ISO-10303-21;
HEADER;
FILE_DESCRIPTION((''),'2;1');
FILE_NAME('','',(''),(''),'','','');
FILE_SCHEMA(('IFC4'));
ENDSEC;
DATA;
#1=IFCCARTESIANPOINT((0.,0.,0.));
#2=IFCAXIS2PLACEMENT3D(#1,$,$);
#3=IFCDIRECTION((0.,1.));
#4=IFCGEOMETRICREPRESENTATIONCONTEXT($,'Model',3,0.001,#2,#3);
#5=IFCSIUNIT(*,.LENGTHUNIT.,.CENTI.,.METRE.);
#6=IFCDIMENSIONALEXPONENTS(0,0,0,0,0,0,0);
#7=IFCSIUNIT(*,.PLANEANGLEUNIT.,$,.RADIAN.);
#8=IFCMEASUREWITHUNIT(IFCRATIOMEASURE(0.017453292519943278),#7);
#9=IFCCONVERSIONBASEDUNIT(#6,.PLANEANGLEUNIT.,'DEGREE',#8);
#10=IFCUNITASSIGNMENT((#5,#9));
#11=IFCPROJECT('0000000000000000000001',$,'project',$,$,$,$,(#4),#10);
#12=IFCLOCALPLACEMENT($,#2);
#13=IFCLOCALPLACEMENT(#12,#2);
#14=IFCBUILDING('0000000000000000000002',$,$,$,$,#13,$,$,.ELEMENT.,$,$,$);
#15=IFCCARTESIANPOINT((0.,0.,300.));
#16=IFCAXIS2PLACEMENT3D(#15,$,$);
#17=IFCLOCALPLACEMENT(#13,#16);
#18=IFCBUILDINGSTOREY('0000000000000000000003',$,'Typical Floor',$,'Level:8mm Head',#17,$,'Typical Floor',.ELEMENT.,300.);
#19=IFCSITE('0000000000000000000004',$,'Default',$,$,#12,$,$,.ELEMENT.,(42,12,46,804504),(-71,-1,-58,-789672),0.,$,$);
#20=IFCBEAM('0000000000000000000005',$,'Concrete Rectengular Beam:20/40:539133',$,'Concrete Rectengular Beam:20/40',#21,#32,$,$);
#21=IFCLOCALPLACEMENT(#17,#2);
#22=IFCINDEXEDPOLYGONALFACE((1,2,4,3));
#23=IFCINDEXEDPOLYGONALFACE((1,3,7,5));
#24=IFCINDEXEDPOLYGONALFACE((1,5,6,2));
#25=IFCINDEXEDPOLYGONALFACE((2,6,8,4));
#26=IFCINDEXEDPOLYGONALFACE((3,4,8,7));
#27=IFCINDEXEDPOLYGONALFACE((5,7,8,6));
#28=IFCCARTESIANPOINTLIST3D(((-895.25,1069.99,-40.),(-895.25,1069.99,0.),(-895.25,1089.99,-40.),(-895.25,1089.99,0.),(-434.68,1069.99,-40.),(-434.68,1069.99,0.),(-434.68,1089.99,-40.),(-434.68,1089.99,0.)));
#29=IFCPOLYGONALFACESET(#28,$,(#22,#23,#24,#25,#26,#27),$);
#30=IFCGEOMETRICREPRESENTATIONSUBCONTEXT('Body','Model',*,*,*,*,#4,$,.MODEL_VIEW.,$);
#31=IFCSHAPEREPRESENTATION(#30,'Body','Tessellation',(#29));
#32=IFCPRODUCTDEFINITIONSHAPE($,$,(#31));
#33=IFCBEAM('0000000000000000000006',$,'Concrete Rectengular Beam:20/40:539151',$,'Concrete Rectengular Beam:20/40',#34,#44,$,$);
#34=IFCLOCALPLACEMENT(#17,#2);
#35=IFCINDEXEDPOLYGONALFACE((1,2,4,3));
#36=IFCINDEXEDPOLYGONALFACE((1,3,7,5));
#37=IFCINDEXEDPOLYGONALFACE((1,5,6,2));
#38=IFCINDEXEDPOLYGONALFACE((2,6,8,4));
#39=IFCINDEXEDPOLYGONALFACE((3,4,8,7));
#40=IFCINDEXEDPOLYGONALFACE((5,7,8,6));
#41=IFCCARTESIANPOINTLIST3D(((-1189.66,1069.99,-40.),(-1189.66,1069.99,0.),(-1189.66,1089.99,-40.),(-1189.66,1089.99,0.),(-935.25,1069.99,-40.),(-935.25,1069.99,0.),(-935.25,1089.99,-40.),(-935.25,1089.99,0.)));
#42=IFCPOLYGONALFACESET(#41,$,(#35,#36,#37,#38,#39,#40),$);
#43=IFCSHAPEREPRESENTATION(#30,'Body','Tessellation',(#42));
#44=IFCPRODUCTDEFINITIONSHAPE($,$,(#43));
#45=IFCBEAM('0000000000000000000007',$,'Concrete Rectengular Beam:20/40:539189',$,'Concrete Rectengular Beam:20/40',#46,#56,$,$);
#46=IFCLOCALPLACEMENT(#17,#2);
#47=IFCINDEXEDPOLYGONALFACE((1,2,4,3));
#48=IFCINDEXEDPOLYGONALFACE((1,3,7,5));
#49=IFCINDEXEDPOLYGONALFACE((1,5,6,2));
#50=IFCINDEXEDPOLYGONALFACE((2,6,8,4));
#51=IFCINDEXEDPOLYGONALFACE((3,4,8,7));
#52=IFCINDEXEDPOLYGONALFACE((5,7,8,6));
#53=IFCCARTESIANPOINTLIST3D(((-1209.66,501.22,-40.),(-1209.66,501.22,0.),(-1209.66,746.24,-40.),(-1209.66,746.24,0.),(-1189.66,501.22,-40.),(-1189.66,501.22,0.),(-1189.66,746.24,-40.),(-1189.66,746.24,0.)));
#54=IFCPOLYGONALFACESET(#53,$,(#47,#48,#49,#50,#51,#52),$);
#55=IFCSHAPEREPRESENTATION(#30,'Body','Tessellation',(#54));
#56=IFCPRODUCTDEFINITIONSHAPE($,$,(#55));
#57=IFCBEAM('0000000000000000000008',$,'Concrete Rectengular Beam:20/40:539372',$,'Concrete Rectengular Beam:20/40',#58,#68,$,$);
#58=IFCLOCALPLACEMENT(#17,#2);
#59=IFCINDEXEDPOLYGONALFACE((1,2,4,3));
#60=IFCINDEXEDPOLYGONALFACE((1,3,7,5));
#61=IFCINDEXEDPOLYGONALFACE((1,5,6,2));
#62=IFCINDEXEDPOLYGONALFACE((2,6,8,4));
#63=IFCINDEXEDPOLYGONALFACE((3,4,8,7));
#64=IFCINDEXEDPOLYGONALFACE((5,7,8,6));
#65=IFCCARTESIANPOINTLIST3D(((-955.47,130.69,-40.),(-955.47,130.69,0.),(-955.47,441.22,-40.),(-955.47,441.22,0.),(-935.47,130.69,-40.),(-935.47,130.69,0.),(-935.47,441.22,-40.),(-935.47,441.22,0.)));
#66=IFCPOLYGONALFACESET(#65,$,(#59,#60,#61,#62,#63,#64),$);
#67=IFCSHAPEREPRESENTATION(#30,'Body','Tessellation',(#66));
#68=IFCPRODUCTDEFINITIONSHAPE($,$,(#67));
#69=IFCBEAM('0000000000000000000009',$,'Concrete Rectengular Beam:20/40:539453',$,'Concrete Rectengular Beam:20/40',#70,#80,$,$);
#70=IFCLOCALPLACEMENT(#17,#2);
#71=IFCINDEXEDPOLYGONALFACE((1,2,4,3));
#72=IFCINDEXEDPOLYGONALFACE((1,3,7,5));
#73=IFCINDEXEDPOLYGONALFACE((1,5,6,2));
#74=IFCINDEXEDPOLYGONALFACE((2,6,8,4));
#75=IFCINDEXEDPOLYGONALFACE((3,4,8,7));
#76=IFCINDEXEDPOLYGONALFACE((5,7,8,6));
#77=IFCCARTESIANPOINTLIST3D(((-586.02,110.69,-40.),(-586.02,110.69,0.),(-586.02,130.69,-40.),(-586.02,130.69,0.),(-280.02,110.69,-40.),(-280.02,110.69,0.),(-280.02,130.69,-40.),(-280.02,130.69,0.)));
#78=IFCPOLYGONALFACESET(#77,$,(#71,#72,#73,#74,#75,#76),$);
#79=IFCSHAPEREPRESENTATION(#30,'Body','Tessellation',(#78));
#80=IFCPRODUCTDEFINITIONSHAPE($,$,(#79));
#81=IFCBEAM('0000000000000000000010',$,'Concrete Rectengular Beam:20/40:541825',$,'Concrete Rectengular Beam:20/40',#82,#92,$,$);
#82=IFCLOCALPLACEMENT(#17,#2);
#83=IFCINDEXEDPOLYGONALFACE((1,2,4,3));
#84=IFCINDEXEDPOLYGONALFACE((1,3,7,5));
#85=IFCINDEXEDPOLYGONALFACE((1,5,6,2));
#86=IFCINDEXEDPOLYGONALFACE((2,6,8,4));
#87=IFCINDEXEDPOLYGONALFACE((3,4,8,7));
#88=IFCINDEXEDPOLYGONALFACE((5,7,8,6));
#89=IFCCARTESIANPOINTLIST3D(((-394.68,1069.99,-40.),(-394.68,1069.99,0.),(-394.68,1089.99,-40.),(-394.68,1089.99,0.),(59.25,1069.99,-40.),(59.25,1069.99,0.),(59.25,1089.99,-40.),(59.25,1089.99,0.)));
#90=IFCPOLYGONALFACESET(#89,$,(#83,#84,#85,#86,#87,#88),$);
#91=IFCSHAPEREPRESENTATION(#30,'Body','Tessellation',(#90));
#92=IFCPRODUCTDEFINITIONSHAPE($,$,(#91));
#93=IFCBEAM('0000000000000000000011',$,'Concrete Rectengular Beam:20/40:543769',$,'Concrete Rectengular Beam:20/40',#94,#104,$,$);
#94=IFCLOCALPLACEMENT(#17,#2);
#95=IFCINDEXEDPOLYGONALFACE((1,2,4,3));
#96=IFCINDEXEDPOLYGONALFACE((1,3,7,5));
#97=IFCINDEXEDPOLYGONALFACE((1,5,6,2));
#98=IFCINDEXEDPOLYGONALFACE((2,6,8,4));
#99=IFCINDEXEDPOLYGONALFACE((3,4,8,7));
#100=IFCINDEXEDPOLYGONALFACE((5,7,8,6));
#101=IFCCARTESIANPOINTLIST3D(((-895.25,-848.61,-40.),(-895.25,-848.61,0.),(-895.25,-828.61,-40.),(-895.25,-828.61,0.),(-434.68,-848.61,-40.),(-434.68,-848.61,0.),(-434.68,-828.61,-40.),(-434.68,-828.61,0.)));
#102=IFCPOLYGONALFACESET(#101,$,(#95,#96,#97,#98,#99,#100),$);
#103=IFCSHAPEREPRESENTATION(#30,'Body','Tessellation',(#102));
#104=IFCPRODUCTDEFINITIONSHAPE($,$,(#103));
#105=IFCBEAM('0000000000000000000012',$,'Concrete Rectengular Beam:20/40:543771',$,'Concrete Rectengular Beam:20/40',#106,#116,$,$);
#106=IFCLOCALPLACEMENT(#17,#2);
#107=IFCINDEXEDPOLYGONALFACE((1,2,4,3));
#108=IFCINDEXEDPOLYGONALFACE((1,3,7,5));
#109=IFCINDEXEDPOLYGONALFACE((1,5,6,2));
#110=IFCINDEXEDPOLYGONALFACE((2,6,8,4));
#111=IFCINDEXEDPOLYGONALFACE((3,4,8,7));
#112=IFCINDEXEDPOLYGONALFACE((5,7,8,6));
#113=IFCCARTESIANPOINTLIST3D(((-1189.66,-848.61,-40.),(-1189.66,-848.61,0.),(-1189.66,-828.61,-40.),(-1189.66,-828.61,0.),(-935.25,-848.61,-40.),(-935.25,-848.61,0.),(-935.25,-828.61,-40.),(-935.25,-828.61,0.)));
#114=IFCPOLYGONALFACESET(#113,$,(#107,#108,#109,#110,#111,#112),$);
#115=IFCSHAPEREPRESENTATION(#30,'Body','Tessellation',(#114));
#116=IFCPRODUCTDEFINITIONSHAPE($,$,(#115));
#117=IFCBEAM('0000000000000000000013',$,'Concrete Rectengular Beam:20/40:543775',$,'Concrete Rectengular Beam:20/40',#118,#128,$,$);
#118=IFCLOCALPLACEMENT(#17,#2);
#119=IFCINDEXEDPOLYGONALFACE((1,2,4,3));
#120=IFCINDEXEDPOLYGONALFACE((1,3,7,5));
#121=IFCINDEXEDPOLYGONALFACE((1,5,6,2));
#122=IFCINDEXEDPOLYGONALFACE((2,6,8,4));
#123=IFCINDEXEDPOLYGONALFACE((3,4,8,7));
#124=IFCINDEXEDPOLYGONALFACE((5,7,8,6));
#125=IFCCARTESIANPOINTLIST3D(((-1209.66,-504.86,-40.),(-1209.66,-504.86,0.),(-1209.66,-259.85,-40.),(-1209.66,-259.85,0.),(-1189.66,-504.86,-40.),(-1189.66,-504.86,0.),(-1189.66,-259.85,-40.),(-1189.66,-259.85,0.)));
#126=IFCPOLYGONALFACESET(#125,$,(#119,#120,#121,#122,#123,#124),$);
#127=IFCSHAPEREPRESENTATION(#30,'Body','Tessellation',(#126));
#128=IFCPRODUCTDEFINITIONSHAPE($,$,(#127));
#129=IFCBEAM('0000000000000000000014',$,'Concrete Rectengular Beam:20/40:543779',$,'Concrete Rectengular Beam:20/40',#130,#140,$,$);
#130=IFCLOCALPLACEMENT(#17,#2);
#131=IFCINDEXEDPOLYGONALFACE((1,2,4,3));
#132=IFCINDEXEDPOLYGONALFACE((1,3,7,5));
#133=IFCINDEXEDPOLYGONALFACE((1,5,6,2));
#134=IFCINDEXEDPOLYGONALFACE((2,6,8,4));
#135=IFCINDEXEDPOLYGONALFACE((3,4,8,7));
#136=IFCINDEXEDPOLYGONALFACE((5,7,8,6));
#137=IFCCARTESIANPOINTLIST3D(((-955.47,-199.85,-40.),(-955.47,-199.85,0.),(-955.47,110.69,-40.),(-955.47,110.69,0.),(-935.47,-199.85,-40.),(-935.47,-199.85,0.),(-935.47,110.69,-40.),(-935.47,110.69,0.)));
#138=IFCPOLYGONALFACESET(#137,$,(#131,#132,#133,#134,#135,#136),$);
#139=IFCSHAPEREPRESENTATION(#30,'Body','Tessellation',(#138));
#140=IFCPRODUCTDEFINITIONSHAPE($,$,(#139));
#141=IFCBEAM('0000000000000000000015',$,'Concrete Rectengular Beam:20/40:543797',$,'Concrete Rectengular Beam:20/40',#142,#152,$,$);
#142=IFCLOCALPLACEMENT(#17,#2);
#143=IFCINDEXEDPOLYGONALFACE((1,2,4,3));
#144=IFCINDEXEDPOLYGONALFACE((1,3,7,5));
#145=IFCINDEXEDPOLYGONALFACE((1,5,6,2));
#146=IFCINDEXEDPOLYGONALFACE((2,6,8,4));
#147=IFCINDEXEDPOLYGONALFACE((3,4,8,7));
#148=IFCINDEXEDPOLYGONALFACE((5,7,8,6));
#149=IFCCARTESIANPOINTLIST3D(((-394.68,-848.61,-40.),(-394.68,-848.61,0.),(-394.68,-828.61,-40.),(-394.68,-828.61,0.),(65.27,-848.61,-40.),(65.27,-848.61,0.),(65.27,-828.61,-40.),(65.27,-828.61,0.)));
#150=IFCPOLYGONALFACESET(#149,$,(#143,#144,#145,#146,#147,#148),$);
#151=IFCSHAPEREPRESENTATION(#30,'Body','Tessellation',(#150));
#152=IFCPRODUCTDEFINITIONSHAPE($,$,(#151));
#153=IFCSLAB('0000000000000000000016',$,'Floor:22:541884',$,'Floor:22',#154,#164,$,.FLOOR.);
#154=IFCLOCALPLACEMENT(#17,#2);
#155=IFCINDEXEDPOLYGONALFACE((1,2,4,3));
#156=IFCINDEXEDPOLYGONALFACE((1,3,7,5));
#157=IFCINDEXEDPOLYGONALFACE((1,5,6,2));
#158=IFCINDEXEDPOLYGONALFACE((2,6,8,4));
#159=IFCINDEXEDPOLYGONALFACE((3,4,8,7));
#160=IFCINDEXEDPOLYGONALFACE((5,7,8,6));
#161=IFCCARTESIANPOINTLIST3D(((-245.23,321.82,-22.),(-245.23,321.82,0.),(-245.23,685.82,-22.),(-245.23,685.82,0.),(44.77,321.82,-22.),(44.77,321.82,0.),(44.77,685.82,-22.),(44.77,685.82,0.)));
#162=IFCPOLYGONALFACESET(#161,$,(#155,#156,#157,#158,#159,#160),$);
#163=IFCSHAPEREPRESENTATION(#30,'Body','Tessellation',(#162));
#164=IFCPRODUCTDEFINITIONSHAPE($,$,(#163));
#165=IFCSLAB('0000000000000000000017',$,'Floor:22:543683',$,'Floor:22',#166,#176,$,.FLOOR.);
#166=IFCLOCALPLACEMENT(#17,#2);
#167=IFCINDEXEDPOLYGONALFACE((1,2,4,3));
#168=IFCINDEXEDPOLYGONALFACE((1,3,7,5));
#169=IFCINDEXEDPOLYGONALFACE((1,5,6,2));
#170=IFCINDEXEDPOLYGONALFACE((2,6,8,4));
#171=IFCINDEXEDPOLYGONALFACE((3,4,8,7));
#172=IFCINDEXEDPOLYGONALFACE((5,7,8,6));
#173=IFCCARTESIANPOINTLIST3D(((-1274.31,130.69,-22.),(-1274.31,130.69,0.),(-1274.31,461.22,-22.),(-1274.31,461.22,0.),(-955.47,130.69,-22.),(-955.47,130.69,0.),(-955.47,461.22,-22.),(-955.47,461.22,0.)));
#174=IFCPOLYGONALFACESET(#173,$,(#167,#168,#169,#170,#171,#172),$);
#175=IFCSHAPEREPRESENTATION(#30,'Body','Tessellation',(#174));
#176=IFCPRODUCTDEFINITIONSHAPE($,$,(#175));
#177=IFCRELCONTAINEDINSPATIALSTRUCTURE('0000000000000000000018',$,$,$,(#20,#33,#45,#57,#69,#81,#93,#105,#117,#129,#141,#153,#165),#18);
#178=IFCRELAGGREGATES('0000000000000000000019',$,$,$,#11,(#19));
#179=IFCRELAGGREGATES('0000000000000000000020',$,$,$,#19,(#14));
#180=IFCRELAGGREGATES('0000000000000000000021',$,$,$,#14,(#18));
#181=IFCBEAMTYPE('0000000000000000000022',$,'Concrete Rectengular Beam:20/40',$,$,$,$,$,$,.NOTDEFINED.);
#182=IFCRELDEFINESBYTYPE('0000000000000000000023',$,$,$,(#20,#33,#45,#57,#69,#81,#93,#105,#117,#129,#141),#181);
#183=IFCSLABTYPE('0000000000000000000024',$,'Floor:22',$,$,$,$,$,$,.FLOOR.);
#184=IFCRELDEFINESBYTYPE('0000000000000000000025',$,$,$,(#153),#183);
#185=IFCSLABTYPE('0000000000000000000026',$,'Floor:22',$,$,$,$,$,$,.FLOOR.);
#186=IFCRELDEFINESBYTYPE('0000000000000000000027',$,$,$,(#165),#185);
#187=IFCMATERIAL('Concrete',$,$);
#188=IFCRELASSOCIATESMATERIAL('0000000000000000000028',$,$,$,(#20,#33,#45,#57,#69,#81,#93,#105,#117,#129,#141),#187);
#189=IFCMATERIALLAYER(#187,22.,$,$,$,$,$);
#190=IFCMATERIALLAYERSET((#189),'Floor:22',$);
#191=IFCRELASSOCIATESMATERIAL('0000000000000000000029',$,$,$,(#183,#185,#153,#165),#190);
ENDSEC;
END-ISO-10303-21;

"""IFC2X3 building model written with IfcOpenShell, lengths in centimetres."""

from ifc_helpers import new_model, entity, si_unit, converted_unit, direction, frame, frame_2d, origin, place, context, subcontext, project, spatial, rectangle, extrude, material, layer, layer_set, layer_usage, type_object, element, save


model = new_model("IFC2X3")

# Units and contexts
model_context = context("Model", 3, precision=0.001, world=origin(), true_north=direction((0.0, 1.0)))
body_context = subcontext(model_context, "Body", "Model", "MODEL_VIEW")
ifc_project = project(units=[si_unit("LENGTHUNIT", "METRE", prefix="CENTI"), converted_unit("PLANEANGLEUNIT", "DEGREE", entity("IfcRatioMeasure", 0.017453292519943278), si_unit("PLANEANGLEUNIT", "RADIAN"), dimensions=[0, 0, 0, 0, 0, 0, 0])], contexts=[model_context])

# Site, building, storey
site_placement = place(None, origin())
site = spatial("IfcSite", under=ifc_project, at=site_placement, Name="Default", CompositionType="ELEMENT", RefLatitude=(42, 12, 46, 804504), RefLongitude=(-71, -1, -58, -789672), RefElevation=0.0)
building_placement = place(site_placement, origin())
building = spatial("IfcBuilding", under=site, at=building_placement, CompositionType="ELEMENT")
storey_placement = place(building_placement, frame((0.0, 0.0, 300.0)))
storey = spatial("IfcBuildingStorey", under=building, at=storey_placement, Name="Typical Floor", ObjectType="Level:8mm Head", LongName="Typical Floor", CompositionType="ELEMENT", Elevation=300.0)

# Beams
ifc_material = material(Name="Concrete")
beam_type = type_object("IfcBeamType", Name="Concrete Rectengular Beam:20/40", PredefinedType="NOTDEFINED")
beam_1_placement = place(storey_placement, frame((-414.68, 1079.99, 0.0), z_axis=(0.0, 0.0, 1.0), x_axis=(-1.0, 0.0, 0.0)))
element("IfcBeam", 1, at=beam_1_placement, inside=storey, type_object=beam_type, material=ifc_material, Name="Concrete Rectengular Beam:20/40:539133", ObjectType="Concrete Rectengular Beam:20/40", context=body_context, shape_type="SweptSolid", body=[
    extrude(rectangle(XDim=40.0, YDim=20.0, at=frame_2d((0.0, 0.0), x_axis=(1.0, 0.0))), frame((20.0, 0.0, -20.0), z_axis=(1.0, 0.0, 0.0), x_axis=(0.0, 0.0, -1.0)), (0.0, 0.0, 1.0), 460.57),
])
beam_2_placement = place(storey_placement, frame((-915.25, 1079.99, 0.0), z_axis=(0.0, 0.0, 1.0), x_axis=(-1.0, 0.0, 0.0)))
element("IfcBeam", 2, at=beam_2_placement, inside=storey, type_object=beam_type, material=ifc_material, Name="Concrete Rectengular Beam:20/40:539151", ObjectType="Concrete Rectengular Beam:20/40", context=body_context, shape_type="SweptSolid", body=[
    extrude(rectangle(XDim=40.0, YDim=20.0, at=frame_2d((0.0, 0.0), x_axis=(1.0, 0.0))), frame((20.0, 0.0, -20.0), z_axis=(1.0, 0.0, 0.0), x_axis=(0.0, 0.0, -1.0)), (0.0, 0.0, 1.0), 254.41),
])
beam_3_placement = place(storey_placement, frame((-1199.66, 766.24, 0.0), z_axis=(0.0, 0.0, 1.0), x_axis=(0.0, -1.0, 0.0)))
element("IfcBeam", 3, at=beam_3_placement, inside=storey, type_object=beam_type, material=ifc_material, Name="Concrete Rectengular Beam:20/40:539189", ObjectType="Concrete Rectengular Beam:20/40", context=body_context, shape_type="SweptSolid", body=[
    extrude(rectangle(XDim=40.0, YDim=20.0, at=frame_2d((0.0, 0.0), x_axis=(1.0, 0.0))), frame((20.0, 0.0, -20.0), z_axis=(1.0, 0.0, 0.0), x_axis=(0.0, 0.0, -1.0)), (0.0, 0.0, 1.0), 245.01),
])
beam_4_placement = place(storey_placement, frame((-945.47, 461.22, 0.0), z_axis=(0.0, 0.0, 1.0), x_axis=(0.0, -1.0, 0.0)))
element("IfcBeam", 4, at=beam_4_placement, inside=storey, type_object=beam_type, material=ifc_material, Name="Concrete Rectengular Beam:20/40:539372", ObjectType="Concrete Rectengular Beam:20/40", context=body_context, shape_type="SweptSolid", body=[
    extrude(rectangle(XDim=40.0, YDim=20.0, at=frame_2d((0.0, 0.0), x_axis=(1.0, 0.0))), frame((20.0, 0.0, -20.0), z_axis=(1.0, 0.0, 0.0), x_axis=(0.0, 0.0, -1.0)), (0.0, 0.0, 1.0), 310.54),
])
beam_5_placement = place(storey_placement, frame((-606.02, 120.69, 0.0)))
element("IfcBeam", 5, at=beam_5_placement, inside=storey, type_object=beam_type, material=ifc_material, Name="Concrete Rectengular Beam:20/40:539453", ObjectType="Concrete Rectengular Beam:20/40", context=body_context, shape_type="SweptSolid", body=[
    extrude(rectangle(XDim=40.0, YDim=20.0, at=frame_2d((0.0, 0.0), x_axis=(1.0, 0.0))), frame((20.0, 0.0, -20.0), z_axis=(1.0, 0.0, 0.0), x_axis=(0.0, 0.0, -1.0)), (0.0, 0.0, 1.0), 306.0),
])
beam_6_placement = place(storey_placement, frame((-414.68, 1079.99, 0.0)))
element("IfcBeam", 6, at=beam_6_placement, inside=storey, type_object=beam_type, material=ifc_material, Name="Concrete Rectengular Beam:20/40:541825", ObjectType="Concrete Rectengular Beam:20/40", context=body_context, shape_type="SweptSolid", body=[
    extrude(rectangle(XDim=40.0, YDim=20.0, at=frame_2d((0.0, 0.0), x_axis=(1.0, 0.0))), frame((20.0, 0.0, -20.0), z_axis=(1.0, 0.0, 0.0), x_axis=(0.0, 0.0, -1.0)), (0.0, 0.0, 1.0), 453.93),
])
beam_7_placement = place(storey_placement, frame((-414.68, -838.61, 0.0), z_axis=(0.0, 0.0, 1.0), x_axis=(-1.0, 0.0, 0.0)))
element("IfcBeam", 7, at=beam_7_placement, inside=storey, type_object=beam_type, material=ifc_material, Name="Concrete Rectengular Beam:20/40:543769", ObjectType="Concrete Rectengular Beam:20/40", context=body_context, shape_type="SweptSolid", body=[
    extrude(rectangle(XDim=40.0, YDim=20.0, at=frame_2d((0.0, 0.0), x_axis=(1.0, 0.0))), frame((20.0, 0.0, -20.0), z_axis=(1.0, 0.0, 0.0), x_axis=(0.0, 0.0, -1.0)), (0.0, 0.0, 1.0), 460.57),
])
beam_8_placement = place(storey_placement, frame((-915.25, -838.61, 0.0), z_axis=(0.0, 0.0, 1.0), x_axis=(-1.0, 0.0, 0.0)))
element("IfcBeam", 8, at=beam_8_placement, inside=storey, type_object=beam_type, material=ifc_material, Name="Concrete Rectengular Beam:20/40:543771", ObjectType="Concrete Rectengular Beam:20/40", context=body_context, shape_type="SweptSolid", body=[
    extrude(rectangle(XDim=40.0, YDim=20.0, at=frame_2d((0.0, 0.0), x_axis=(1.0, 0.0))), frame((20.0, 0.0, -20.0), z_axis=(1.0, 0.0, 0.0), x_axis=(0.0, 0.0, -1.0)), (0.0, 0.0, 1.0), 254.41),
])
beam_9_placement = place(storey_placement, frame((-1199.66, -524.86, 0.0), z_axis=(0.0, 0.0, 1.0), x_axis=(0.0, 1.0, 0.0)))
element("IfcBeam", 9, at=beam_9_placement, inside=storey, type_object=beam_type, material=ifc_material, Name="Concrete Rectengular Beam:20/40:543775", ObjectType="Concrete Rectengular Beam:20/40", context=body_context, shape_type="SweptSolid", body=[
    extrude(rectangle(XDim=40.0, YDim=20.0, at=frame_2d((0.0, 0.0), x_axis=(1.0, 0.0))), frame((20.0, 0.0, -20.0), z_axis=(1.0, 0.0, 0.0), x_axis=(0.0, 0.0, -1.0)), (0.0, 0.0, 1.0), 245.01),
])
beam_10_placement = place(storey_placement, frame((-945.47, -219.85, 0.0), z_axis=(0.0, 0.0, 1.0), x_axis=(0.0, 1.0, 0.0)))
element("IfcBeam", 10, at=beam_10_placement, inside=storey, type_object=beam_type, material=ifc_material, Name="Concrete Rectengular Beam:20/40:543779", ObjectType="Concrete Rectengular Beam:20/40", context=body_context, shape_type="SweptSolid", body=[
    extrude(rectangle(XDim=40.0, YDim=20.0, at=frame_2d((0.0, 0.0), x_axis=(1.0, 0.0))), frame((20.0, 0.0, -20.0), z_axis=(1.0, 0.0, 0.0), x_axis=(0.0, 0.0, -1.0)), (0.0, 0.0, 1.0), 310.54),
])
beam_11_placement = place(storey_placement, frame((-414.68, -838.61, 0.0)))
element("IfcBeam", 11, at=beam_11_placement, inside=storey, type_object=beam_type, material=ifc_material, Name="Concrete Rectengular Beam:20/40:543797", ObjectType="Concrete Rectengular Beam:20/40", context=body_context, shape_type="SweptSolid", body=[
    extrude(rectangle(XDim=40.0, YDim=20.0, at=frame_2d((0.0, 0.0), x_axis=(1.0, 0.0))), frame((20.0, 0.0, -20.0), z_axis=(1.0, 0.0, 0.0), x_axis=(0.0, 0.0, -1.0)), (0.0, 0.0, 1.0), 459.95),
])

# Slabs
ifc_layer = layer(ifc_material, 22.0)
ifc_layer_set = layer_set([ifc_layer], Name="Floor:22")
ifc_layer_usage_1 = layer_usage(ifc_layer_set, "AXIS3", "POSITIVE", 0.0)
slab_type_1 = type_object("IfcSlabType", Name="Floor:22", PredefinedType="FLOOR", material=ifc_layer_set)
slab_1_placement = place(storey_placement, origin())
element("IfcSlab", 12, at=slab_1_placement, inside=storey, type_object=slab_type_1, material=ifc_layer_usage_1, Name="Floor:22:541884", ObjectType="Floor:22", PredefinedType="FLOOR", context=body_context, shape_type="SweptSolid", body=[
    extrude(rectangle(XDim=364.0, YDim=290.0, at=frame_2d((0.0, 0.0), x_axis=(1.0, 0.0))), frame((-100.23, 503.82, 0.0), z_axis=(0.0, 0.0, -1.0), x_axis=(0.0, 1.0, 0.0)), (0.0, 0.0, 1.0), 22.0),
])
ifc_layer_usage_2 = layer_usage(ifc_layer_set, "AXIS3", "POSITIVE", 0.0)
slab_type_2 = type_object("IfcSlabType", Name="Floor:22", PredefinedType="FLOOR", material=ifc_layer_set)
slab_2_placement = place(storey_placement, origin())
element("IfcSlab", 13, at=slab_2_placement, inside=storey, type_object=slab_type_2, material=ifc_layer_usage_2, Name="Floor:22:543683", ObjectType="Floor:22", PredefinedType="FLOOR", context=body_context, shape_type="SweptSolid", body=[
    extrude(rectangle(XDim=330.54, YDim=318.84, at=frame_2d((0.0, 0.0), x_axis=(1.0, 0.0))), frame((-1114.89, 295.96, 0.0), z_axis=(0.0, 0.0, -1.0), x_axis=(0.0, 1.0, 0.0)), (0.0, 0.0, 1.0), 22.0),
])

save(model, "model.ifc")
